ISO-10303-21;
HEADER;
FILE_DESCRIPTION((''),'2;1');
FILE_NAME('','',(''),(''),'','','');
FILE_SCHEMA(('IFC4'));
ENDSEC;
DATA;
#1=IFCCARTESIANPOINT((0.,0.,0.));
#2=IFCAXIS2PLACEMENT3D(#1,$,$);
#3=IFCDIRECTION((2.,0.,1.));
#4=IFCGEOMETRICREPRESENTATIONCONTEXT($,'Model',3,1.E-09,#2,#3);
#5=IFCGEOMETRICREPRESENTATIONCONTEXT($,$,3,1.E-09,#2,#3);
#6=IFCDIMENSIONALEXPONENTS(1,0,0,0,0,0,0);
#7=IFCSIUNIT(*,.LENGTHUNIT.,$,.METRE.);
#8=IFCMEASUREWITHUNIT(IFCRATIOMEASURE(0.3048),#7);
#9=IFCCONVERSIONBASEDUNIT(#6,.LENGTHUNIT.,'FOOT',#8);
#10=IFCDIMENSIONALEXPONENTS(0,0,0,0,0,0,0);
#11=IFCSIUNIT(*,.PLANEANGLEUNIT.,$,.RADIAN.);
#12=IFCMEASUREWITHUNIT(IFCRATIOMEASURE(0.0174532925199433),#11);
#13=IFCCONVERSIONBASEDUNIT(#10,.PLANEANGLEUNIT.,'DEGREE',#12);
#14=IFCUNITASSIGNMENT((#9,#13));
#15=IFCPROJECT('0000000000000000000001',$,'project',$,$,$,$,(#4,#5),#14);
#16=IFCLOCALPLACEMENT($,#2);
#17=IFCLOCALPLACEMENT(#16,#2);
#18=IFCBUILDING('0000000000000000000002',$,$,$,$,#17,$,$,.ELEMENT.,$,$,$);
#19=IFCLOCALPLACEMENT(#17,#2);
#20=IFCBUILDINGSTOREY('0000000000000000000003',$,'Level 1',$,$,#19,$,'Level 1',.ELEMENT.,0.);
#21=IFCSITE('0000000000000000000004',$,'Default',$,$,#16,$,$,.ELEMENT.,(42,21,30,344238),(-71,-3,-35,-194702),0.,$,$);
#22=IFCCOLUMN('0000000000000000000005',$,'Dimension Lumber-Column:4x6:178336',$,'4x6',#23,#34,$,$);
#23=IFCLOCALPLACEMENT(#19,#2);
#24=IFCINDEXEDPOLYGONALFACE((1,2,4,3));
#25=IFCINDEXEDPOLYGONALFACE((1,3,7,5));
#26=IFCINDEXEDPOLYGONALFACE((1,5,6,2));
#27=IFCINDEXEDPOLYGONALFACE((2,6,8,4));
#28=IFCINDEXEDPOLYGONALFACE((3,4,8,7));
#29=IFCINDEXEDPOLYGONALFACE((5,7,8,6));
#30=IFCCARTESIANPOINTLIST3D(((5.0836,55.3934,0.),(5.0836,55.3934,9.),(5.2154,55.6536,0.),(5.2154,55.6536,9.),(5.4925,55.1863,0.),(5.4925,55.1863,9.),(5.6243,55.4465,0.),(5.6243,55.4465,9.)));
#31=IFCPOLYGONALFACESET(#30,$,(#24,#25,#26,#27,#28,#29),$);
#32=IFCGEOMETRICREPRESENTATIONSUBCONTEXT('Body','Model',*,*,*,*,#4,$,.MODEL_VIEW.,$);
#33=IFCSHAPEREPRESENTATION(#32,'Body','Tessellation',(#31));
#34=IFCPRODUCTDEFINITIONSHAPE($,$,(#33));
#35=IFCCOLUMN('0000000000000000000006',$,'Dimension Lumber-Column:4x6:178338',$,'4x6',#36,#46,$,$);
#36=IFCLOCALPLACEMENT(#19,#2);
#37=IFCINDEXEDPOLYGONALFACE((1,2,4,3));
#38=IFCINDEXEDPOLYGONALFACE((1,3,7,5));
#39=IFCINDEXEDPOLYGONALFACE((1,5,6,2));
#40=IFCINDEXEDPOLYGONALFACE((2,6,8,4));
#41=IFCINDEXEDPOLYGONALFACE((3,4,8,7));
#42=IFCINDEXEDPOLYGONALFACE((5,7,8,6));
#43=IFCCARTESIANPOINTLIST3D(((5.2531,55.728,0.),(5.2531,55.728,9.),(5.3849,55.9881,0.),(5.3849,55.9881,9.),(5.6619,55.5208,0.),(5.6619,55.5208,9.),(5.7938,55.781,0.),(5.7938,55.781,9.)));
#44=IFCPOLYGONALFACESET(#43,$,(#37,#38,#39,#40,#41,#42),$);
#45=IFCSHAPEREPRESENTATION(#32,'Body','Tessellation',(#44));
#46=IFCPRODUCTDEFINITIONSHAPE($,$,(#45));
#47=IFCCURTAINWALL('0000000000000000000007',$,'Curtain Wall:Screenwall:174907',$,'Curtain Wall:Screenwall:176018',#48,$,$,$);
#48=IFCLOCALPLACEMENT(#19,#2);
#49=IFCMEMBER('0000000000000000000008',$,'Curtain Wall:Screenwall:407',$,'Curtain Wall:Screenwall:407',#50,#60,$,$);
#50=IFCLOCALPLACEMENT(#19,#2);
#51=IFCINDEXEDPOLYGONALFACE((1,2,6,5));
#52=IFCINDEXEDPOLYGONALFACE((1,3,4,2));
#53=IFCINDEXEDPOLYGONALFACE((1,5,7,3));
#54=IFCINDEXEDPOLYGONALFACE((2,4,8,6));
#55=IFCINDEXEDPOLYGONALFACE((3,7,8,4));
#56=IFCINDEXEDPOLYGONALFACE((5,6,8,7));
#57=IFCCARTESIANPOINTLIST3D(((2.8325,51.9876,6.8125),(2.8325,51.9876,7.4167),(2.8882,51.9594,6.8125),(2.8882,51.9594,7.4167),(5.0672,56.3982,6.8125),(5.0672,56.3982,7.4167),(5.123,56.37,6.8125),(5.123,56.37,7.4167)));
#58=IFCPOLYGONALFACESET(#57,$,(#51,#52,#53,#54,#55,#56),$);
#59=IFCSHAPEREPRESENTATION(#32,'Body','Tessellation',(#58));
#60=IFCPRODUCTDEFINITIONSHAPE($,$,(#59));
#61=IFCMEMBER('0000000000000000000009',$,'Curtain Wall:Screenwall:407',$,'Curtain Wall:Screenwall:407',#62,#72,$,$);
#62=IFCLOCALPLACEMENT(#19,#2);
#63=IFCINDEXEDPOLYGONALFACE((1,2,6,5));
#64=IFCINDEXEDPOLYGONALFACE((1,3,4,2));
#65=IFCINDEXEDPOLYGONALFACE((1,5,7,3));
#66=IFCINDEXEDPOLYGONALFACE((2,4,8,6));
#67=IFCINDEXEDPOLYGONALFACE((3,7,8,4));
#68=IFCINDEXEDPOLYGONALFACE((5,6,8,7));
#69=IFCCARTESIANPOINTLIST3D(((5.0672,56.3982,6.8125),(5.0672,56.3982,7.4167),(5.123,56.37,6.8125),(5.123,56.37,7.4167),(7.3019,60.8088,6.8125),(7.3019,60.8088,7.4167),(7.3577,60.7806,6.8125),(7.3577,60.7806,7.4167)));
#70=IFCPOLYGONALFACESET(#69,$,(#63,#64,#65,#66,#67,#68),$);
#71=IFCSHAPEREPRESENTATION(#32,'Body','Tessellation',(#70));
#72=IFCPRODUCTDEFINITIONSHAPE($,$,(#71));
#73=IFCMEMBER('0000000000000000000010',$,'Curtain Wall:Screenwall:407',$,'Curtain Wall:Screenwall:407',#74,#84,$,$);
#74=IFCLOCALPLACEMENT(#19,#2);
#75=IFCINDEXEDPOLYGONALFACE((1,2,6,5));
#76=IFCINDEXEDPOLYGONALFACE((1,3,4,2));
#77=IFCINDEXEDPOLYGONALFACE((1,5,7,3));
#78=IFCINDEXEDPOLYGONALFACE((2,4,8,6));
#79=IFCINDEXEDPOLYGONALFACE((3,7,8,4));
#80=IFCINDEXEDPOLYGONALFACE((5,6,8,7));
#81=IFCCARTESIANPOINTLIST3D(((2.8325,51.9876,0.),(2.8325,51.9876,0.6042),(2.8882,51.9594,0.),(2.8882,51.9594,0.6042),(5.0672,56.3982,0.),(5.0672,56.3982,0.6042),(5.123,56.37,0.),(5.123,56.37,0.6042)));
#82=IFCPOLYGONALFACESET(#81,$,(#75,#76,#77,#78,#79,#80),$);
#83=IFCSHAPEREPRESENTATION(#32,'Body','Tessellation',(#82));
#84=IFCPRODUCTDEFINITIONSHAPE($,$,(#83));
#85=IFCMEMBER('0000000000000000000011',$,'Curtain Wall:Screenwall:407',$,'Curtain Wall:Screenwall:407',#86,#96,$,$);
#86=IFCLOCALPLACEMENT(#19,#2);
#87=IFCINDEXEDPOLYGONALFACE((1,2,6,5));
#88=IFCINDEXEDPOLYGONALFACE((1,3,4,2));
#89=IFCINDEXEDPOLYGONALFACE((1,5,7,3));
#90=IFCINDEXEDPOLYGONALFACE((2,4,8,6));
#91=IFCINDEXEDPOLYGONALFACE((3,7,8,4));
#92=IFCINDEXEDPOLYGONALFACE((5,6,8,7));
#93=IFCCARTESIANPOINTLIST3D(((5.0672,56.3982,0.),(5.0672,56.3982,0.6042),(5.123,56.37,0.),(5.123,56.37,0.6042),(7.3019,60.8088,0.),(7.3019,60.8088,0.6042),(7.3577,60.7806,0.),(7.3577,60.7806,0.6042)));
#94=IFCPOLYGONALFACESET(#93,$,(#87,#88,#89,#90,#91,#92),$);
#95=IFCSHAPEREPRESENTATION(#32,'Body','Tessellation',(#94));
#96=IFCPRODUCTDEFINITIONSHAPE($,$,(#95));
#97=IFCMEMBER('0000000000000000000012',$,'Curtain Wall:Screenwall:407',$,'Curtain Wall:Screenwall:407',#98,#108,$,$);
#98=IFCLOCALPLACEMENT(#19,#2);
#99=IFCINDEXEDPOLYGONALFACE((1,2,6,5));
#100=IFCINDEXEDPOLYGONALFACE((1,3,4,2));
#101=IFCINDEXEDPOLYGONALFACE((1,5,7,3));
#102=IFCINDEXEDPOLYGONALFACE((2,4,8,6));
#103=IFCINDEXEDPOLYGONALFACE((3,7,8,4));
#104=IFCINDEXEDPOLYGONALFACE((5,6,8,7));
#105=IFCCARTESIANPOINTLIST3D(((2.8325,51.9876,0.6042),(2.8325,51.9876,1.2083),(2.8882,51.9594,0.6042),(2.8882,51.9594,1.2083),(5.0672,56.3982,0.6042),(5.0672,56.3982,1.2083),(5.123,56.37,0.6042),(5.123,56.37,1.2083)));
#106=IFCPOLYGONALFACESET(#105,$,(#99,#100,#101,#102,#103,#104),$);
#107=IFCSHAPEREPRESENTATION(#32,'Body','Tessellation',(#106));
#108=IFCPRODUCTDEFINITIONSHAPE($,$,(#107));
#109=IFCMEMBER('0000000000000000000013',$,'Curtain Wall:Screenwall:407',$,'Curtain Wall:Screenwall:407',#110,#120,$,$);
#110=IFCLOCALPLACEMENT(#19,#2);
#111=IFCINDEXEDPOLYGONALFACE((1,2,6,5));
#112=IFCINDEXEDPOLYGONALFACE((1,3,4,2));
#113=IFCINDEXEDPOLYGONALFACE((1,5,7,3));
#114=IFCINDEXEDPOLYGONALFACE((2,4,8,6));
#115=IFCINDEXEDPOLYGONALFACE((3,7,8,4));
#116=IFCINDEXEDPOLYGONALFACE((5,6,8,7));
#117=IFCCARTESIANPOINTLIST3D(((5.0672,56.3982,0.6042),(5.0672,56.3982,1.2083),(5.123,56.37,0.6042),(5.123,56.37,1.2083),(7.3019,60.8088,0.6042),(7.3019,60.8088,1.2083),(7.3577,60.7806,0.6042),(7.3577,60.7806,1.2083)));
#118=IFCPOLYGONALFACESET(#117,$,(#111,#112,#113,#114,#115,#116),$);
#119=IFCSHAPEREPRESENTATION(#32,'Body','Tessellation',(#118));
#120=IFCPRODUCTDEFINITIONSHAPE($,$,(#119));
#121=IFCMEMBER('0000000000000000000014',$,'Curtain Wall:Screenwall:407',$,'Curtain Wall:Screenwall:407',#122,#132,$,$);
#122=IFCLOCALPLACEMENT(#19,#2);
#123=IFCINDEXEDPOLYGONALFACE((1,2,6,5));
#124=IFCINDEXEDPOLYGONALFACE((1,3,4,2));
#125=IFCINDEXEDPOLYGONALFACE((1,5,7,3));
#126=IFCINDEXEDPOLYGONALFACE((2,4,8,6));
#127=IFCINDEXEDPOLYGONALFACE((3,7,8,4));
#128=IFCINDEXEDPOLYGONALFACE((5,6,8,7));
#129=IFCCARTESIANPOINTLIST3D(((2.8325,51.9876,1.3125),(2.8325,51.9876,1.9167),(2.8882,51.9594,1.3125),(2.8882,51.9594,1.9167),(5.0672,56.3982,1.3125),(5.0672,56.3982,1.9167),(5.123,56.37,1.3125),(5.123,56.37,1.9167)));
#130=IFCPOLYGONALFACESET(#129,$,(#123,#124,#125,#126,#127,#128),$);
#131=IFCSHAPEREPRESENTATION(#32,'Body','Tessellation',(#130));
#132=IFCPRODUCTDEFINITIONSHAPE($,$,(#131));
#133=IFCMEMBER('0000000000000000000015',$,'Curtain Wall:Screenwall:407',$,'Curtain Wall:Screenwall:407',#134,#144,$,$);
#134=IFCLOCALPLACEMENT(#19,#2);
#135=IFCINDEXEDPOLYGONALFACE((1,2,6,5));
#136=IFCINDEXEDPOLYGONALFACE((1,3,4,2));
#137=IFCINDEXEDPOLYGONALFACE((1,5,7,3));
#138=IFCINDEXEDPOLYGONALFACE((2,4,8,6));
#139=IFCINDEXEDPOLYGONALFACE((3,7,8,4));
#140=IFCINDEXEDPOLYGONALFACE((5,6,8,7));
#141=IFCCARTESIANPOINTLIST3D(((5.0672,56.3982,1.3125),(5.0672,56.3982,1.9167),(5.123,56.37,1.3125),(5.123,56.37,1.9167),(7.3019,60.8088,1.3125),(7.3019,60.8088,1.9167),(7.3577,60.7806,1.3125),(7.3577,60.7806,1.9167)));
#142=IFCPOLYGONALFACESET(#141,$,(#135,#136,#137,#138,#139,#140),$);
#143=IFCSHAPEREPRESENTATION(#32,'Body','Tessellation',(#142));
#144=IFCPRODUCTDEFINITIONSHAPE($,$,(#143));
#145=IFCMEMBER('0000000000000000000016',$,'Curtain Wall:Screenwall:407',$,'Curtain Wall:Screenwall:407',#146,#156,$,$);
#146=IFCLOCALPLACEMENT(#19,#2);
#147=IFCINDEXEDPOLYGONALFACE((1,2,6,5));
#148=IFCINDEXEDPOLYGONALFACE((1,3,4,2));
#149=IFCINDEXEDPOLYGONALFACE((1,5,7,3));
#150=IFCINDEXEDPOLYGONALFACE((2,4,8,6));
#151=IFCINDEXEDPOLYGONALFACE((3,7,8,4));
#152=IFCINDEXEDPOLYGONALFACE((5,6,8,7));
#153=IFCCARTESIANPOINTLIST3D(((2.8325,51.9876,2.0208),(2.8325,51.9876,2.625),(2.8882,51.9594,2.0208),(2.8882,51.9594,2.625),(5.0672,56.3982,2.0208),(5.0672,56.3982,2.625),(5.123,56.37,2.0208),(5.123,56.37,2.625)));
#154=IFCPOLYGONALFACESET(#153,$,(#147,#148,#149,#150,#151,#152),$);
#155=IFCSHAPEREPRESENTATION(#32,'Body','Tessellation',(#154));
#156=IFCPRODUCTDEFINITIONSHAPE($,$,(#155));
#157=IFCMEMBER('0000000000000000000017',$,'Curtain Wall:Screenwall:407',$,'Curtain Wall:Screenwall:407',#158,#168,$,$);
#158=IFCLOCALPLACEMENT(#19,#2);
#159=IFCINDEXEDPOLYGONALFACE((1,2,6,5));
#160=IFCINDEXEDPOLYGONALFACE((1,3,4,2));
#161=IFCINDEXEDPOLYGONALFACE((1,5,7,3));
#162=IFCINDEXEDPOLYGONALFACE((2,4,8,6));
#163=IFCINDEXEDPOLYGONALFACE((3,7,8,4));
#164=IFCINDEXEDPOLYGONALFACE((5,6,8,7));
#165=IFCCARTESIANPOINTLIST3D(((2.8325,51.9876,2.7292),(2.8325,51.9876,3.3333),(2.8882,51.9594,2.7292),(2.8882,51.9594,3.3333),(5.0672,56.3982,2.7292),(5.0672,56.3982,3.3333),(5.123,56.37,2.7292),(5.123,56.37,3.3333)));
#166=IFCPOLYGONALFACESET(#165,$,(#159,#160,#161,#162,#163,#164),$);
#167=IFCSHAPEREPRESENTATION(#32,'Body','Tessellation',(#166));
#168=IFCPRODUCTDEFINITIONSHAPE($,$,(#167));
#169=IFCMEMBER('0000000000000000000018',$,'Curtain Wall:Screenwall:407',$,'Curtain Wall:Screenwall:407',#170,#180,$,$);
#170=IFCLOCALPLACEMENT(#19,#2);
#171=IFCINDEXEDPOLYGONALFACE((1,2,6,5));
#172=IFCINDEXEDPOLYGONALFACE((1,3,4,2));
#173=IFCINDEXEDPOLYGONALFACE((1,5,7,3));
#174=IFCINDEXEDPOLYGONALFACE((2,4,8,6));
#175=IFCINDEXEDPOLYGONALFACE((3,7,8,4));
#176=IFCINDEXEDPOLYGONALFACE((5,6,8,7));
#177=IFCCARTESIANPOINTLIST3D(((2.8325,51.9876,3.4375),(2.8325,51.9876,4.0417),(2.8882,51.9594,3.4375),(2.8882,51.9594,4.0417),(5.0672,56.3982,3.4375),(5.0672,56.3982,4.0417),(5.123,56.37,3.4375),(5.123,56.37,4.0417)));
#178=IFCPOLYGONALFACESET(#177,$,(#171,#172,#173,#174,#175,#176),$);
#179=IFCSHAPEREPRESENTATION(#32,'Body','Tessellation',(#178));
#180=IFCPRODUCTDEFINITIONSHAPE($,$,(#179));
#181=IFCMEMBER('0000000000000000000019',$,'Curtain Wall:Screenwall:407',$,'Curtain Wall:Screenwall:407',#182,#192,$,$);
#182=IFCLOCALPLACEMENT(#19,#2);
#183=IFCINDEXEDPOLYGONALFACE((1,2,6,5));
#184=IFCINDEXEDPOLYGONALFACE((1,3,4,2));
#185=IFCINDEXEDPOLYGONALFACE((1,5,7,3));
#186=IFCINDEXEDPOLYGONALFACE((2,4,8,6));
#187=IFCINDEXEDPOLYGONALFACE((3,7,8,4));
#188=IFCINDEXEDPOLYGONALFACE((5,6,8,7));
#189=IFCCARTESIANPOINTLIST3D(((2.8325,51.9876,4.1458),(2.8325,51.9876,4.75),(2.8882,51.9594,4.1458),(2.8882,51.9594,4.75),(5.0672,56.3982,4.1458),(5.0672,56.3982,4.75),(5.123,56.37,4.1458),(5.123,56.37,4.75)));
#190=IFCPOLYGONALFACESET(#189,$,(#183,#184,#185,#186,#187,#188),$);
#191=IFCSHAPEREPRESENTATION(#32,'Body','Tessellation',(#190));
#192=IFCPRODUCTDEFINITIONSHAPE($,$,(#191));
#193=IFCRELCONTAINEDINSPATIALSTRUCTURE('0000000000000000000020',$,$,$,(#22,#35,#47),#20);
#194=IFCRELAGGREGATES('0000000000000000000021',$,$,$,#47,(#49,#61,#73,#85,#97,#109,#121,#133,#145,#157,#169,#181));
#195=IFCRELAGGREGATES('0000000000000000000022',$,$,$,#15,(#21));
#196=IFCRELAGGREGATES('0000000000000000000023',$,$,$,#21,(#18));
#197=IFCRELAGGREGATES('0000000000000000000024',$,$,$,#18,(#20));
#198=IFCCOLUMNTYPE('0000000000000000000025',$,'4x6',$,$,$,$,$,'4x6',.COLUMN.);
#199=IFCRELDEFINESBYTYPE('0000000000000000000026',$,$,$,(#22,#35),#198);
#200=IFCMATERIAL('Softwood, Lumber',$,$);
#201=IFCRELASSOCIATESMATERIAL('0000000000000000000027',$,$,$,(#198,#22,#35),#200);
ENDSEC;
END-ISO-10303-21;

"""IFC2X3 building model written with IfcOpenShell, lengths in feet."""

from ifc_helpers import new_model, entity, si_unit, converted_unit, direction, frame, frame_2d, origin, origin_2d_with_axis, place, context, subcontext, project, spatial, rectangle, extrude, source, transform, mapped, material, type_object, type_shapes, element, aggregate, save


model = new_model("IFC2X3")

# Units and contexts
model_context = context("Model", 3, precision=1e-09, world=origin(), true_north=direction((2.0, 0.0, 1.0)))
context_of_model = context(None, 3, precision=1e-09, world=origin(), true_north=direction((2.0, 0.0, 1.0)))
body_context = subcontext(model_context, "Body", "Model", "MODEL_VIEW")
ifc_project = project(units=[converted_unit("LENGTHUNIT", "FOOT", entity("IfcRatioMeasure", 0.3048), si_unit("LENGTHUNIT", "METRE"), dimensions=[1, 0, 0, 0, 0, 0, 0]), converted_unit("PLANEANGLEUNIT", "DEGREE", entity("IfcRatioMeasure", 0.0174532925199433), si_unit("PLANEANGLEUNIT", "RADIAN"), dimensions=[0, 0, 0, 0, 0, 0, 0])], contexts=[model_context, context_of_model])

# Site, building, storey
site_placement = place(None, origin())
site = spatial("IfcSite", under=ifc_project, at=site_placement, Name="Default", CompositionType="ELEMENT", RefLatitude=(42, 21, 30, 344238), RefLongitude=(-71, -3, -35, -194702), RefElevation=0.0)
building_placement = place(site_placement, origin())
building = spatial("IfcBuilding", under=site, at=building_placement, CompositionType="ELEMENT")
storey_placement = place(building_placement, origin())
storey = spatial("IfcBuildingStorey", under=building, at=storey_placement, Name="Level 1", LongName="Level 1", CompositionType="ELEMENT", Elevation=0.0)

# Columns
ifc_material = material(Name="Softwood, Lumber")
column_type = type_object("IfcColumnType", Name="4x6", ElementType="4x6", PredefinedType="COLUMN", material=ifc_material)
shared_shape = source(origin(), body_context, "Body", "SweptSolid", [
    extrude(rectangle(XDim=0.2917, YDim=0.4583, at=origin_2d_with_axis()), frame((0.0, 0.0, 0.0), z_axis=(0.0, 0.0, 1.0), x_axis=(-1.0, 0.0, 0.0)), (0.0, 0.0, 1.0), 9.0),
])
type_shapes(column_type, [shared_shape])
for number, where, z_axis, x_axis, name in (
    (1, (5.3539, 55.42, 0.0), (0.0, 0.0, 1.0), (0.451968, 0.892034, 0.0), "Dimension Lumber-Column:4x6:178336"),
    (2, (5.5234, 55.7545, 0.0), (0.0, 0.0, 1.0), (0.451968, 0.892034, 0.0), "Dimension Lumber-Column:4x6:178338"),
):
    element("IfcColumn", number, at=place(storey_placement, frame(where, z_axis=z_axis, x_axis=x_axis)), inside=storey, type_object=column_type, material=ifc_material, Name=name, ObjectType="4x6", context=body_context, shape_type="MappedRepresentation", body=[
        mapped(shared_shape, transform((0.0, 0.0, 0.0), scale=1.0)),
    ])

# Curtain wall, members
curtain_wall_1_placement = place(storey_placement, origin())
curtain_wall_1 = element("IfcCurtainWall", 3, at=curtain_wall_1_placement, inside=storey, Name="Curtain Wall:Screenwall:174907", ObjectType="Curtain Wall:Screenwall:176018")
member_1_placement = place(curtain_wall_1_placement, frame((2.8325, 51.9594, 6.8125)))
member_1 = element("IfcMember", 4, at=member_1_placement, Name="Curtain Wall:Screenwall:407", ObjectType="Curtain Wall:Screenwall:407", context=body_context, shape_type="SweptSolid", body=[
    extrude(rectangle(XDim=4.9444, YDim=0.0625, at=frame_2d((0.0, 0.0), x_axis=(1.0, 0.0))), frame((1.1452, 2.2194, 0.0), z_axis=(0.0, 0.0, 1.0), x_axis=(-0.451968, -0.892034, 0.0)), (0.0, 0.0, 1.0), 0.6042),
])
member_2_placement = place(curtain_wall_1_placement, frame((5.0672, 56.37, 6.8125)))
member_2 = element("IfcMember", 5, at=member_2_placement, Name="Curtain Wall:Screenwall:407", ObjectType="Curtain Wall:Screenwall:407", context=body_context, shape_type="SweptSolid", body=[
    extrude(rectangle(XDim=4.9444, YDim=0.0625, at=frame_2d((0.0, 0.0), x_axis=(1.0, 0.0))), frame((1.1452, 2.2194, 0.0), z_axis=(0.0, 0.0, 1.0), x_axis=(-0.451968, -0.892034, 0.0)), (0.0, 0.0, 1.0), 0.6042),
])
member_3_placement = place(curtain_wall_1_placement, frame((2.8325, 51.9594, 0.0)))
member_3 = element("IfcMember", 6, at=member_3_placement, Name="Curtain Wall:Screenwall:407", ObjectType="Curtain Wall:Screenwall:407", context=body_context, shape_type="SweptSolid", body=[
    extrude(rectangle(XDim=4.9444, YDim=0.0625, at=frame_2d((0.0, 0.0), x_axis=(1.0, 0.0))), frame((1.1452, 2.2194, 0.0), z_axis=(0.0, 0.0, 1.0), x_axis=(0.451968, 0.892034, 0.0)), (0.0, 0.0, 1.0), 0.6042),
])
member_4_placement = place(curtain_wall_1_placement, frame((5.0672, 56.37, 0.0)))
member_4 = element("IfcMember", 7, at=member_4_placement, Name="Curtain Wall:Screenwall:407", ObjectType="Curtain Wall:Screenwall:407", context=body_context, shape_type="SweptSolid", body=[
    extrude(rectangle(XDim=4.9444, YDim=0.0625, at=frame_2d((0.0, 0.0), x_axis=(1.0, 0.0))), frame((1.1452, 2.2194, 0.0), z_axis=(0.0, 0.0, 1.0), x_axis=(0.451968, 0.892034, 0.0)), (0.0, 0.0, 1.0), 0.6042),
])
member_5_placement = place(curtain_wall_1_placement, frame((2.8325, 51.9594, 0.6042)))
member_5 = element("IfcMember", 8, at=member_5_placement, Name="Curtain Wall:Screenwall:407", ObjectType="Curtain Wall:Screenwall:407", context=body_context, shape_type="SweptSolid", body=[
    extrude(rectangle(XDim=4.9444, YDim=0.0625, at=frame_2d((0.0, 0.0), x_axis=(1.0, 0.0))), frame((1.1452, 2.2194, 0.0), z_axis=(0.0, 0.0, 1.0), x_axis=(-0.451968, -0.892034, 0.0)), (0.0, 0.0, 1.0), 0.6042),
])
member_6_placement = place(curtain_wall_1_placement, frame((5.0672, 56.37, 0.6042)))
member_6 = element("IfcMember", 9, at=member_6_placement, Name="Curtain Wall:Screenwall:407", ObjectType="Curtain Wall:Screenwall:407", context=body_context, shape_type="SweptSolid", body=[
    extrude(rectangle(XDim=4.9444, YDim=0.0625, at=frame_2d((0.0, 0.0), x_axis=(1.0, 0.0))), frame((1.1452, 2.2194, 0.0), z_axis=(0.0, 0.0, 1.0), x_axis=(-0.451968, -0.892034, 0.0)), (0.0, 0.0, 1.0), 0.6042),
])
member_7_placement = place(curtain_wall_1_placement, frame((2.8325, 51.9594, 1.3125)))
member_7 = element("IfcMember", 10, at=member_7_placement, Name="Curtain Wall:Screenwall:407", ObjectType="Curtain Wall:Screenwall:407", context=body_context, shape_type="SweptSolid", body=[
    extrude(rectangle(XDim=4.9444, YDim=0.0625, at=frame_2d((0.0, 0.0), x_axis=(1.0, 0.0))), frame((1.1452, 2.2194, 0.0), z_axis=(0.0, 0.0, 1.0), x_axis=(-0.451968, -0.892034, 0.0)), (0.0, 0.0, 1.0), 0.6042),
])
member_8_placement = place(curtain_wall_1_placement, frame((5.0672, 56.37, 1.3125)))
member_8 = element("IfcMember", 11, at=member_8_placement, Name="Curtain Wall:Screenwall:407", ObjectType="Curtain Wall:Screenwall:407", context=body_context, shape_type="SweptSolid", body=[
    extrude(rectangle(XDim=4.9444, YDim=0.0625, at=frame_2d((0.0, 0.0), x_axis=(1.0, 0.0))), frame((1.1452, 2.2194, 0.0), z_axis=(0.0, 0.0, 1.0), x_axis=(-0.451968, -0.892034, 0.0)), (0.0, 0.0, 1.0), 0.6042),
])
member_9_placement = place(curtain_wall_1_placement, frame((2.8325, 51.9594, 2.0208)))
member_9 = element("IfcMember", 12, at=member_9_placement, Name="Curtain Wall:Screenwall:407", ObjectType="Curtain Wall:Screenwall:407", context=body_context, shape_type="SweptSolid", body=[
    extrude(rectangle(XDim=4.9444, YDim=0.0625, at=frame_2d((0.0, 0.0), x_axis=(1.0, 0.0))), frame((1.1452, 2.2194, 0.0), z_axis=(0.0, 0.0, 1.0), x_axis=(-0.451968, -0.892034, 0.0)), (0.0, 0.0, 1.0), 0.6042),
])
member_10_placement = place(curtain_wall_1_placement, frame((2.8325, 51.9594, 2.7292)))
member_10 = element("IfcMember", 13, at=member_10_placement, Name="Curtain Wall:Screenwall:407", ObjectType="Curtain Wall:Screenwall:407", context=body_context, shape_type="SweptSolid", body=[
    extrude(rectangle(XDim=4.9444, YDim=0.0625, at=frame_2d((0.0, 0.0), x_axis=(1.0, 0.0))), frame((1.1452, 2.2194, 0.0), z_axis=(0.0, 0.0, 1.0), x_axis=(-0.451968, -0.892034, 0.0)), (0.0, 0.0, 1.0), 0.6042),
])
member_11_placement = place(curtain_wall_1_placement, frame((2.8325, 51.9594, 3.4375)))
member_11 = element("IfcMember", 14, at=member_11_placement, Name="Curtain Wall:Screenwall:407", ObjectType="Curtain Wall:Screenwall:407", context=body_context, shape_type="SweptSolid", body=[
    extrude(rectangle(XDim=4.9444, YDim=0.0625, at=frame_2d((0.0, 0.0), x_axis=(1.0, 0.0))), frame((1.1452, 2.2194, 0.0), z_axis=(0.0, 0.0, 1.0), x_axis=(-0.451968, -0.892034, 0.0)), (0.0, 0.0, 1.0), 0.6042),
])
member_12_placement = place(curtain_wall_1_placement, frame((2.8325, 51.9594, 4.1458)))
member_12 = element("IfcMember", 15, at=member_12_placement, Name="Curtain Wall:Screenwall:407", ObjectType="Curtain Wall:Screenwall:407", context=body_context, shape_type="SweptSolid", body=[
    extrude(rectangle(XDim=4.9444, YDim=0.0625, at=frame_2d((0.0, 0.0), x_axis=(1.0, 0.0))), frame((1.1452, 2.2194, 0.0), z_axis=(0.0, 0.0, 1.0), x_axis=(-0.451968, -0.892034, 0.0)), (0.0, 0.0, 1.0), 0.6042),
])
aggregate(curtain_wall_1, [member_1, member_2, member_3, member_4, member_5, member_6, member_7, member_8, member_9, member_10, member_11, member_12])

save(model, "model.ifc")
